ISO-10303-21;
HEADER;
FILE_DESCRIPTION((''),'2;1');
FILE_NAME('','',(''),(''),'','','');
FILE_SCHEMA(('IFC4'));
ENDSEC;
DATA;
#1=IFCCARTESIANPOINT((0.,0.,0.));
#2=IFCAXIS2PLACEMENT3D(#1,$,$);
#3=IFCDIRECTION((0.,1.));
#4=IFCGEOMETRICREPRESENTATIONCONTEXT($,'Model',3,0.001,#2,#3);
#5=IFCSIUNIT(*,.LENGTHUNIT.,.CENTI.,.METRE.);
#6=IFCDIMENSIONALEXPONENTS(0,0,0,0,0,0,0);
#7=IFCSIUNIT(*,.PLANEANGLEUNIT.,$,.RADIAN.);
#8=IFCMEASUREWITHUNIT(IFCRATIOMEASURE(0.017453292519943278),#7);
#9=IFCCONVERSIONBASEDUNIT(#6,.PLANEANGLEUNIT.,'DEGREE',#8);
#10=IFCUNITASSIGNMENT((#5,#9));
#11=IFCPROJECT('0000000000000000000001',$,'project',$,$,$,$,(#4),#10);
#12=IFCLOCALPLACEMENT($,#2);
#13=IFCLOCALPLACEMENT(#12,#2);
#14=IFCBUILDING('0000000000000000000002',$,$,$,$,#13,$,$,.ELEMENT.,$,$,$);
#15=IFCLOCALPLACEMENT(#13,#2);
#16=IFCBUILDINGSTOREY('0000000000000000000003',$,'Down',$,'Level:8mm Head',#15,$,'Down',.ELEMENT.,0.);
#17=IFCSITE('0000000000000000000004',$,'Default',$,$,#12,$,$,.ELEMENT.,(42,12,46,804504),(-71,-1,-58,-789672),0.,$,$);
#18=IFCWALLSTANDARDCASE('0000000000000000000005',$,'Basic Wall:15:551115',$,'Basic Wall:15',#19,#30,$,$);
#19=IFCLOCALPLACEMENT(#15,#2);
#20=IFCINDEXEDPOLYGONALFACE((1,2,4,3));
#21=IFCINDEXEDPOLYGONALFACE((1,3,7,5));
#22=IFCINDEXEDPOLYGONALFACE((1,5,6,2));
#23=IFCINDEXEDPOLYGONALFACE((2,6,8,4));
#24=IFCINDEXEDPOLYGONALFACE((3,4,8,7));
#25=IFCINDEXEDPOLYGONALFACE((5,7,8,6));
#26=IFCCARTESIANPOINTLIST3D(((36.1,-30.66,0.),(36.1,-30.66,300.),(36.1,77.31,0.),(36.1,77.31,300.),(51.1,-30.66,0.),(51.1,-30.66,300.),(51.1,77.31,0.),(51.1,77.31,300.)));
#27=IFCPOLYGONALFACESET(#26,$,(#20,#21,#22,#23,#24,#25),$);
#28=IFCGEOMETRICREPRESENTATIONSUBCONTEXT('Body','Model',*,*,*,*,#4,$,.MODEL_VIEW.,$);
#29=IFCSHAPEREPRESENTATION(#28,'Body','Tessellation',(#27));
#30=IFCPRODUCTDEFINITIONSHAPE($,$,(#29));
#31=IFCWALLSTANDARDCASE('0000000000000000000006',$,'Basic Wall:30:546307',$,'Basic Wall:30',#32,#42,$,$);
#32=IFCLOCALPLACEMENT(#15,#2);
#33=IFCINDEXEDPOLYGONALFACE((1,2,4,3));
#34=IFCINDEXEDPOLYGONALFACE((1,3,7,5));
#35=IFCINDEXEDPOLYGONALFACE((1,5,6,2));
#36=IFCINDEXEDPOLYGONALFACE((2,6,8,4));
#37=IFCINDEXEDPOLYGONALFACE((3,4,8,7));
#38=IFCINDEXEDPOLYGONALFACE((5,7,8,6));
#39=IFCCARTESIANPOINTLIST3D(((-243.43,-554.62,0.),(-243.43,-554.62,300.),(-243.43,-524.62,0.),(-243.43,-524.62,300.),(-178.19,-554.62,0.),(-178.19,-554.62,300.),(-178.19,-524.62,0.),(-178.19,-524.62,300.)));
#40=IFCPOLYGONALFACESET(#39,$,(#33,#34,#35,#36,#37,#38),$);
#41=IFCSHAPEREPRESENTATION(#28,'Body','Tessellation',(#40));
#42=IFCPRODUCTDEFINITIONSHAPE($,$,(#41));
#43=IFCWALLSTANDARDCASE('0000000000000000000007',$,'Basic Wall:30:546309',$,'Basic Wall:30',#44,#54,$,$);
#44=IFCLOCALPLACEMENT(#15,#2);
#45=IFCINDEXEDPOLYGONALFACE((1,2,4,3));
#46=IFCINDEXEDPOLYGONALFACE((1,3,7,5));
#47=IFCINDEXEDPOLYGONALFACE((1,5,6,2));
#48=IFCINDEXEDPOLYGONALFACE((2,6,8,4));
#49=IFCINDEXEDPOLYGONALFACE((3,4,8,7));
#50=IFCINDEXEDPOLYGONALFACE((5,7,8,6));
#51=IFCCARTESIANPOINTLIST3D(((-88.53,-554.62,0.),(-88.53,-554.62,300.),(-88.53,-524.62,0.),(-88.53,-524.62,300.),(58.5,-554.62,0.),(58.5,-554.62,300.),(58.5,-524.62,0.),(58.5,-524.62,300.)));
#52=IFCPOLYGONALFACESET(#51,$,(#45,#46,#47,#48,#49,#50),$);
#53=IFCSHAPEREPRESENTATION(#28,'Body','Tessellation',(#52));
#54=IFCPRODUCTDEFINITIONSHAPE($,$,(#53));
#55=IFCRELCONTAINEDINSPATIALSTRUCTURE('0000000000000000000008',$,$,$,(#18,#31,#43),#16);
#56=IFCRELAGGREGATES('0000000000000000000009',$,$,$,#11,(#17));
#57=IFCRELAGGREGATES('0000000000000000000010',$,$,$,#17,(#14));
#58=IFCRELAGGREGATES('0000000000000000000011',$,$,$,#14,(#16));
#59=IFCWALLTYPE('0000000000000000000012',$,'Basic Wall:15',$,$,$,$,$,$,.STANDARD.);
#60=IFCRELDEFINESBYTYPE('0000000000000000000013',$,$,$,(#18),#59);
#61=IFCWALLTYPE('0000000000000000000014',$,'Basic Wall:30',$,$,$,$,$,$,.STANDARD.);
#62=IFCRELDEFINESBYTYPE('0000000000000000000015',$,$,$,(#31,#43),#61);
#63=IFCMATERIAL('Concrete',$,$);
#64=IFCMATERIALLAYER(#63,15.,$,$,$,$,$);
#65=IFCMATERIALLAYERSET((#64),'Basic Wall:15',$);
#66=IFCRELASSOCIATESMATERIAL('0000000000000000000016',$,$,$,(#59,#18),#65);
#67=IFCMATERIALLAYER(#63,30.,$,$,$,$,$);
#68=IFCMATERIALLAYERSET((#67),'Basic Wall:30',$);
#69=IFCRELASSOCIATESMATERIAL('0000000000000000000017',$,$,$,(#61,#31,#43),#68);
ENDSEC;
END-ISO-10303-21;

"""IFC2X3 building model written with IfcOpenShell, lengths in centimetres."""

from ifc_helpers import new_model, entity, si_unit, converted_unit, direction, frame, frame_2d, origin, place, context, subcontext, project, spatial, rectangle, extrude, material, layer, layer_set, layer_usage, type_object, element, save


model = new_model("IFC2X3")

# Units and contexts
model_context = context("Model", 3, precision=0.001, world=origin(), true_north=direction((0.0, 1.0)))
body_context = subcontext(model_context, "Body", "Model", "MODEL_VIEW")
ifc_project = project(units=[si_unit("LENGTHUNIT", "METRE", prefix="CENTI"), converted_unit("PLANEANGLEUNIT", "DEGREE", entity("IfcRatioMeasure", 0.017453292519943278), si_unit("PLANEANGLEUNIT", "RADIAN"), dimensions=[0, 0, 0, 0, 0, 0, 0])], contexts=[model_context])

# Site, building, storey
site_placement = place(None, origin())
site = spatial("IfcSite", under=ifc_project, at=site_placement, Name="Default", CompositionType="ELEMENT", RefLatitude=(42, 12, 46, 804504), RefLongitude=(-71, -1, -58, -789672), RefElevation=0.0)
building_placement = place(site_placement, origin())
building = spatial("IfcBuilding", under=site, at=building_placement, CompositionType="ELEMENT")
storey_placement = place(building_placement, origin())
storey = spatial("IfcBuildingStorey", under=building, at=storey_placement, Name="Down", ObjectType="Level:8mm Head", LongName="Down", CompositionType="ELEMENT", Elevation=0.0)

# Shared definitions
ifc_material = material(Name="Concrete")

# Walls
ifc_layer_1 = layer(ifc_material, 15.0)
ifc_layer_set_1 = layer_set([ifc_layer_1], Name="Basic Wall:15")
wall_type_1 = type_object("IfcWallType", Name="Basic Wall:15", PredefinedType="STANDARD", material=ifc_layer_set_1)
ifc_layer_usage_1 = layer_usage(ifc_layer_set_1, "AXIS2", "NEGATIVE", 7.5)
wall_1_placement = place(storey_placement, frame((43.6, -30.66, 0.0), z_axis=(0.0, 0.0, 1.0), x_axis=(0.0, 1.0, 0.0)))
element("IfcWallStandardCase", 1, at=wall_1_placement, inside=storey, type_object=wall_type_1, material=ifc_layer_usage_1, Name="Basic Wall:15:551115", ObjectType="Basic Wall:15", context=body_context, shape_type="SweptSolid", body=[
    extrude(rectangle(XDim=107.97, YDim=15.0, at=frame_2d((53.99, 0.0), x_axis=(-1.0, 0.0))), origin(), (0.0, 0.0, 1.0), 300.0),
])
ifc_layer_2 = layer(ifc_material, 30.0)
ifc_layer_set_2 = layer_set([ifc_layer_2], Name="Basic Wall:30")
ifc_layer_usage_2 = layer_usage(ifc_layer_set_2, "AXIS2", "POSITIVE", -15.0)
wall_type_2 = type_object("IfcWallType", Name="Basic Wall:30", PredefinedType="STANDARD", material=ifc_layer_set_2)
wall_2_placement = place(storey_placement, frame((-243.43, -539.62, 0.0)))
element("IfcWallStandardCase", 2, at=wall_2_placement, inside=storey, type_object=wall_type_2, material=ifc_layer_usage_2, Name="Basic Wall:30:546307", ObjectType="Basic Wall:30", context=body_context, shape_type="SweptSolid", body=[
    extrude(rectangle(XDim=65.24, YDim=30.0, at=frame_2d((32.62, 0.0), x_axis=(-1.0, 0.0))), origin(), (0.0, 0.0, 1.0), 300.0),
])
ifc_layer_usage_3 = layer_usage(ifc_layer_set_2, "AXIS2", "POSITIVE", -15.0)
wall_3_placement = place(storey_placement, frame((-88.53, -539.62, 0.0)))
element("IfcWallStandardCase", 3, at=wall_3_placement, inside=storey, type_object=wall_type_2, material=ifc_layer_usage_3, Name="Basic Wall:30:546309", ObjectType="Basic Wall:30", context=body_context, shape_type="SweptSolid", body=[
    extrude(rectangle(XDim=147.03, YDim=30.0, at=frame_2d((73.51, 0.0), x_axis=(-1.0, 0.0))), origin(), (0.0, 0.0, 1.0), 300.0),
])

save(model, "model.ifc")
